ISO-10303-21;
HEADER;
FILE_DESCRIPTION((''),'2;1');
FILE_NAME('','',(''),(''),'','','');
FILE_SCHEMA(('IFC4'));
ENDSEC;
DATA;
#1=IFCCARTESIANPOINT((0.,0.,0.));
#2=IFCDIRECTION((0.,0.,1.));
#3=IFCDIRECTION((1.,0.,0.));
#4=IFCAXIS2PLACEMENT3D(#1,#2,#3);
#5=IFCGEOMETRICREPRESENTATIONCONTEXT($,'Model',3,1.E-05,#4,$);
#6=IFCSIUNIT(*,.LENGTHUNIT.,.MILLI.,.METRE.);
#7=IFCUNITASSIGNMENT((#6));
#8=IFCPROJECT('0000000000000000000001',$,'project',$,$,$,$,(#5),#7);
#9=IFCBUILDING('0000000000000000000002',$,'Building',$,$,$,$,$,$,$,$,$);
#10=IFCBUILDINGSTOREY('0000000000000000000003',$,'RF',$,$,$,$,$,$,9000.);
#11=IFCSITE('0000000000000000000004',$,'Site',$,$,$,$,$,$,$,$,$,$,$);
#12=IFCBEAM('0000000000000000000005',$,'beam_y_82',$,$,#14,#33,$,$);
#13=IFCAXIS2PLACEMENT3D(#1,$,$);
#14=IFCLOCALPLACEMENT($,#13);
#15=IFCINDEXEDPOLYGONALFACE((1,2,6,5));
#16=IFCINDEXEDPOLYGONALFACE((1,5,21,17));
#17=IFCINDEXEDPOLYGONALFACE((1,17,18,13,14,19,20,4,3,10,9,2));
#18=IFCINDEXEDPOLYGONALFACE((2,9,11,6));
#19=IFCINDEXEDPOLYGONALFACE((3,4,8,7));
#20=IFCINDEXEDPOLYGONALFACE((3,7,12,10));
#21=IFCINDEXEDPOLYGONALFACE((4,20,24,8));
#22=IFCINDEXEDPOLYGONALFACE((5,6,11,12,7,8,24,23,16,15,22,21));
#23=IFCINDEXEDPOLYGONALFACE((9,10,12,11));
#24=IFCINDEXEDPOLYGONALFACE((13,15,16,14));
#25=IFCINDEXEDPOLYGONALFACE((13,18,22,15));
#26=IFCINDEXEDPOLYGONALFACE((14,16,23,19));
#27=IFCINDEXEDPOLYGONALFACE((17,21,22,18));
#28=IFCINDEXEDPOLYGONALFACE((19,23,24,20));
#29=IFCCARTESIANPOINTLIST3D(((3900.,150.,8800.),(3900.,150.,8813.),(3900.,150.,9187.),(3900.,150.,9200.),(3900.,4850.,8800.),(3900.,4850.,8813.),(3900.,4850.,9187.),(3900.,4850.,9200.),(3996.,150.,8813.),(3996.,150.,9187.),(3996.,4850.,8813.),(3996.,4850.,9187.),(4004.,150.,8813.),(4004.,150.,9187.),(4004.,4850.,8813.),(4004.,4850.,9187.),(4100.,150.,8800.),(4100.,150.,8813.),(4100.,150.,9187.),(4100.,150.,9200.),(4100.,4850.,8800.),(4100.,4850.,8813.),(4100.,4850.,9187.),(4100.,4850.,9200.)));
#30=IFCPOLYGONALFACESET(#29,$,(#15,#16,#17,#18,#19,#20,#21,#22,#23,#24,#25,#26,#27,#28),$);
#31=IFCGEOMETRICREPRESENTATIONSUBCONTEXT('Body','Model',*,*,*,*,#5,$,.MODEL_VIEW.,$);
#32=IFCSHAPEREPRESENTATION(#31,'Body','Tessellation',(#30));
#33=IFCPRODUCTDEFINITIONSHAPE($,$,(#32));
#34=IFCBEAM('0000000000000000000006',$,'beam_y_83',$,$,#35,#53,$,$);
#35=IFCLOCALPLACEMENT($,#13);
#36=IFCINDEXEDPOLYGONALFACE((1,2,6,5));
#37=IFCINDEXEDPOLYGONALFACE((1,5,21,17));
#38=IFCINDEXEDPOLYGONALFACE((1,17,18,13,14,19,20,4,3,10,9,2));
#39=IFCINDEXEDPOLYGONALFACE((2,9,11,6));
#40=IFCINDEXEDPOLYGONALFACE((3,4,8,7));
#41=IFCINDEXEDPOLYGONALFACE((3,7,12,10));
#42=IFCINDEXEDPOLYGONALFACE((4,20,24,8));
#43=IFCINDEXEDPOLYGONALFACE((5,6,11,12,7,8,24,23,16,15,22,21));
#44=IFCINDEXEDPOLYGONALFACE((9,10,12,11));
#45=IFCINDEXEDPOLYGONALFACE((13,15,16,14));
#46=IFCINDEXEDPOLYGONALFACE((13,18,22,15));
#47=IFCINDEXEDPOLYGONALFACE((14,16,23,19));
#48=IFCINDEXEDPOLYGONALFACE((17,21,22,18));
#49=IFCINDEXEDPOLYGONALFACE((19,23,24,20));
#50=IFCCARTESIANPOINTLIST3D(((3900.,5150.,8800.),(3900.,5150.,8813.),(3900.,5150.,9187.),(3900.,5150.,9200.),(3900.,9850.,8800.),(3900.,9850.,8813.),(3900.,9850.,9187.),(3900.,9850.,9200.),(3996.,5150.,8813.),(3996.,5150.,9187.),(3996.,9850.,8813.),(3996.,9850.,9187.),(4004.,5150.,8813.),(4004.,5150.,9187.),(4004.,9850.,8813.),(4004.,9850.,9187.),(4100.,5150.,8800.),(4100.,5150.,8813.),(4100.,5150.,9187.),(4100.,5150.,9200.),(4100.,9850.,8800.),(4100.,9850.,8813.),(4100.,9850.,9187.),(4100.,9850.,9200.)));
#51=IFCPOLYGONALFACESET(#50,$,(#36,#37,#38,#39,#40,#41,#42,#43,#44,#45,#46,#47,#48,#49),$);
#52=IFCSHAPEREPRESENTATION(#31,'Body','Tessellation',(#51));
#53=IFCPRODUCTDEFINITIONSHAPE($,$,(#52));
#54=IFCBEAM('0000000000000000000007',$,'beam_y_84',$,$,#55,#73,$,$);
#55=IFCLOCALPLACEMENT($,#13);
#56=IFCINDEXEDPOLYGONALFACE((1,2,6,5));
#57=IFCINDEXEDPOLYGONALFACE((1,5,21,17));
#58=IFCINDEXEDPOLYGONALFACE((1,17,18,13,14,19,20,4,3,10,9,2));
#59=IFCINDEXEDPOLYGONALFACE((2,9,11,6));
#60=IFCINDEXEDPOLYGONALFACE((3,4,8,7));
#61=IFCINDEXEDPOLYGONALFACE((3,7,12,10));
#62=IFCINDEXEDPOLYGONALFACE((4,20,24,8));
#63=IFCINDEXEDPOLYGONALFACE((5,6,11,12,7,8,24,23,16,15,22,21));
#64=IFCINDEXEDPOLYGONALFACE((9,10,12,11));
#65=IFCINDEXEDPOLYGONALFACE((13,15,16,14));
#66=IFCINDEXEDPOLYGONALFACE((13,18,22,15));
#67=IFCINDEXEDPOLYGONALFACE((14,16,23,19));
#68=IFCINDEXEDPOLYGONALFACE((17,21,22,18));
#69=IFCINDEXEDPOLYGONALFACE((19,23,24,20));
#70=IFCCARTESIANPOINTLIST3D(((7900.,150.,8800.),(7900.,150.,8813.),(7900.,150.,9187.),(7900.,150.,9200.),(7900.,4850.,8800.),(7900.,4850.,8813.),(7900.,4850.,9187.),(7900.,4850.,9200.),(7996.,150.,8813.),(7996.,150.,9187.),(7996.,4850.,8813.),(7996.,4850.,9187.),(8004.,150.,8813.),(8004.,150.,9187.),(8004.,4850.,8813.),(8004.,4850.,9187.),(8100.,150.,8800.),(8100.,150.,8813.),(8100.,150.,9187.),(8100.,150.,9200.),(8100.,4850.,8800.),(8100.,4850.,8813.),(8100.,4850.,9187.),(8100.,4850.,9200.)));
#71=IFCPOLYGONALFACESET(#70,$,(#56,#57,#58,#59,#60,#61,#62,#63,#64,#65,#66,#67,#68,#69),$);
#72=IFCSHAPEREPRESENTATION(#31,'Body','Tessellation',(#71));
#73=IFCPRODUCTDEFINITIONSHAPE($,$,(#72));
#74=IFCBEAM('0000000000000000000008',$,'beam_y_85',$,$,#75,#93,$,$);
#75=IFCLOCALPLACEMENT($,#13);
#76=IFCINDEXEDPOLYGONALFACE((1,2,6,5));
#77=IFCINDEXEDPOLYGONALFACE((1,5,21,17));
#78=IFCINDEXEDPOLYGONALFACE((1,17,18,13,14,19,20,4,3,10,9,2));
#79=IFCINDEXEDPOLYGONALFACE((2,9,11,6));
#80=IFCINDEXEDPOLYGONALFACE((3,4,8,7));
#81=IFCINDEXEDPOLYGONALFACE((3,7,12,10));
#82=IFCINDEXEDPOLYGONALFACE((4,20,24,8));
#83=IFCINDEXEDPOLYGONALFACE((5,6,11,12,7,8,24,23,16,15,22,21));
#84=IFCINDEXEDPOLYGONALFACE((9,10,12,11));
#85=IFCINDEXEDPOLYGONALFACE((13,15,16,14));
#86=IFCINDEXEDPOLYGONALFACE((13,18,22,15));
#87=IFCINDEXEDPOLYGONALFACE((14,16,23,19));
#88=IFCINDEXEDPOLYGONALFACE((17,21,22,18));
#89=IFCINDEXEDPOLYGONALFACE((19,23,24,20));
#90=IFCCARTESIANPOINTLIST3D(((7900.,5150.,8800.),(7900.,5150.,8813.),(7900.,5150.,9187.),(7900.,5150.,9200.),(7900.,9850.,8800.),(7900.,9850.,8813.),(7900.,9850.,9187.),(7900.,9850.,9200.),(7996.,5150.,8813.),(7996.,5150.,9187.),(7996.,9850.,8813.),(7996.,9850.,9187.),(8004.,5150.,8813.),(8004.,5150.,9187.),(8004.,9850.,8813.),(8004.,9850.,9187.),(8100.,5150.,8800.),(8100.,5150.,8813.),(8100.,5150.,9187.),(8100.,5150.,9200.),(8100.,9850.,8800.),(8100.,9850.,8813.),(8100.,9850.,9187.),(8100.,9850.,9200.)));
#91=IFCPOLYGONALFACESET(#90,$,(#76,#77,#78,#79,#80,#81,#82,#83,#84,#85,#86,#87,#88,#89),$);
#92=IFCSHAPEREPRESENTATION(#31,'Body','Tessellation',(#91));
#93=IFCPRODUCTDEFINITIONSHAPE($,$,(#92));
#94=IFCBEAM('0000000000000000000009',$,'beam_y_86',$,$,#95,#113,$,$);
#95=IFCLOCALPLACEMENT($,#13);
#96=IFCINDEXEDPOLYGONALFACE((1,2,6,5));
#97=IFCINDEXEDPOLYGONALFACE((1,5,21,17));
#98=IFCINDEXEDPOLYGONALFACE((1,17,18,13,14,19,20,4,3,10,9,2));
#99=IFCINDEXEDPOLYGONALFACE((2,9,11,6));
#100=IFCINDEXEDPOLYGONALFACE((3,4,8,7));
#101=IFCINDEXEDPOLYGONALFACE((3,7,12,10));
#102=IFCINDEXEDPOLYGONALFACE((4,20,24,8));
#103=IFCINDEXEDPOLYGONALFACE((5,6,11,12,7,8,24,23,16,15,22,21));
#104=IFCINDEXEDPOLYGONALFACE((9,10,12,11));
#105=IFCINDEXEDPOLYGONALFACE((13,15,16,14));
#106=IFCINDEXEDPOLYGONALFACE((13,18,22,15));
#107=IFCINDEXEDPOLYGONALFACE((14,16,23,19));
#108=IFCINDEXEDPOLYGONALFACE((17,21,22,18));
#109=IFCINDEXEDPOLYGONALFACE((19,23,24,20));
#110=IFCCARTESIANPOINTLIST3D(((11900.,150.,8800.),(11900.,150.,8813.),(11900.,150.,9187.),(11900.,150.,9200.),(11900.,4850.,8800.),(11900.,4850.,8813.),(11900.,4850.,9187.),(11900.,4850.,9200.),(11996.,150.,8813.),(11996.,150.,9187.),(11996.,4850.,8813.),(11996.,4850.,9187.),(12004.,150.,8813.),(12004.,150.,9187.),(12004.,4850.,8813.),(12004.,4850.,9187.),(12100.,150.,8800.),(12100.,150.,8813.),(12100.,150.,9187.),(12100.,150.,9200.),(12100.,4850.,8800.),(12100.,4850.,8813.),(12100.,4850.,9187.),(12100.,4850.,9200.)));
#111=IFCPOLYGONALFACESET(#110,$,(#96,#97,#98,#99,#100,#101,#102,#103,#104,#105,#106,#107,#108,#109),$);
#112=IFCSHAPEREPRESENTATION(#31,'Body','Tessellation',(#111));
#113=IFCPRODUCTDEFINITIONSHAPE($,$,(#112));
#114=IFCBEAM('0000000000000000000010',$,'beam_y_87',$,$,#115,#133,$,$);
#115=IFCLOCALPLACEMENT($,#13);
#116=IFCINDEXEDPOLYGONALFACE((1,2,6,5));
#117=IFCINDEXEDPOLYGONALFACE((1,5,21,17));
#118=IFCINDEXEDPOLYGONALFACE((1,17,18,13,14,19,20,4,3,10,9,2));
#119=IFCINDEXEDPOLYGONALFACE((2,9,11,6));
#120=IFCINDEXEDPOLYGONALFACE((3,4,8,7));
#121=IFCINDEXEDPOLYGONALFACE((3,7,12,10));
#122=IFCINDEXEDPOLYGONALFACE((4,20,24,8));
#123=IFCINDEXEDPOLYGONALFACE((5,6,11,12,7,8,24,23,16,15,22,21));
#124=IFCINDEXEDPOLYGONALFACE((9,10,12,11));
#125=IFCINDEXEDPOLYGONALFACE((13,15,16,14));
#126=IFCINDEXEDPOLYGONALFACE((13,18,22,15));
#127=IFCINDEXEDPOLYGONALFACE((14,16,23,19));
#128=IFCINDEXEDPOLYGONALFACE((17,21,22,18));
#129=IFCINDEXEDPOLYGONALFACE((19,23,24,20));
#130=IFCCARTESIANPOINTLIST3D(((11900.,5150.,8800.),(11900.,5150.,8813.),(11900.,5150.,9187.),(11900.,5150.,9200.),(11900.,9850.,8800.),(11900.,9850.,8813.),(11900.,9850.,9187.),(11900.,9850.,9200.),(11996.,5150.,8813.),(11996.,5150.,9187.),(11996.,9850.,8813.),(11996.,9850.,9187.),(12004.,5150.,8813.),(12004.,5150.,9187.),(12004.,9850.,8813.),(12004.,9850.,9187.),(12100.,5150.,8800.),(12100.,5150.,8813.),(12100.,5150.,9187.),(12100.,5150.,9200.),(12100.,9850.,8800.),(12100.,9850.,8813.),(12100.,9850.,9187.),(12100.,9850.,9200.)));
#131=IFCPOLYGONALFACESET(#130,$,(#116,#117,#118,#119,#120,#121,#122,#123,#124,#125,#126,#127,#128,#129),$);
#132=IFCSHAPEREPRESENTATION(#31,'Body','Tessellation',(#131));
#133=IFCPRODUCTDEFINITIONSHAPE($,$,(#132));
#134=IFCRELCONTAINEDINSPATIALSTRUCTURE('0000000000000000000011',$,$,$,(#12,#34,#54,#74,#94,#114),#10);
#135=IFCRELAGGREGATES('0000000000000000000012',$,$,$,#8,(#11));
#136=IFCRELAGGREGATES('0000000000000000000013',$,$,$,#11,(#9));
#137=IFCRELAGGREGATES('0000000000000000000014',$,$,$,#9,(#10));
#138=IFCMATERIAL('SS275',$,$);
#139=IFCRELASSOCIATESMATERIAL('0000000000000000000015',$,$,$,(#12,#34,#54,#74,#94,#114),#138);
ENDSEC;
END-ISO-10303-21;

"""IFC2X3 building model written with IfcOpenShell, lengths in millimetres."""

from ifc_helpers import new_model, si_unit, frame, origin, origin_with_axes, origin_2d_with_axis, place, context, subcontext, project, spatial, i_section, extrude, material, element, save


model = new_model("IFC2X3")

# Units and contexts
model_context = context("Model", 3, precision=1e-05, world=origin_with_axes())
body_context = subcontext(model_context, "Body", "Model", "MODEL_VIEW")
ifc_project = project(units=[si_unit("LENGTHUNIT", "METRE", prefix="MILLI")], contexts=[model_context])

# Site, building, storey
site = spatial("IfcSite", under=ifc_project, Name="Site")
building = spatial("IfcBuilding", under=site, Name="Building")
storey = spatial("IfcBuildingStorey", under=building, Name="RF", Elevation=9000.0)

# Beams
ifc_material = material(Name="SS275")
for number, where, z_axis, x_axis, name in (
    (1, (4000.0, 150.0, 9000.0), (0.0, 1.0, 0.0), (-1.0, 0.0, 0.0), "beam_y_82"),
    (2, (4000.0, 5150.0, 9000.0), (0.0, 1.0, 0.0), (-1.0, 0.0, 0.0), "beam_y_83"),
    (3, (8000.0, 150.0, 9000.0), (0.0, 1.0, 0.0), (-1.0, 0.0, 0.0), "beam_y_84"),
    (4, (8000.0, 5150.0, 9000.0), (0.0, 1.0, 0.0), (-1.0, 0.0, 0.0), "beam_y_85"),
    (5, (12000.0, 150.0, 9000.0), (0.0, 1.0, 0.0), (-1.0, 0.0, 0.0), "beam_y_86"),
    (6, (12000.0, 5150.0, 9000.0), (0.0, 1.0, 0.0), (-1.0, 0.0, 0.0), "beam_y_87"),
):
    element("IfcBeam", number, at=place(None, frame(where, z_axis=z_axis, x_axis=x_axis)), inside=storey, material=ifc_material, Name=name, context=body_context, shape_type="SweptSolid", body=[
        extrude(i_section(OverallWidth=200.0, OverallDepth=400.0, WebThickness=8.0, FlangeThickness=13.0, at=origin_2d_with_axis()), origin(), (0.0, 0.0, 1.0), 4700.0),
    ])

save(model, "model.ifc")
